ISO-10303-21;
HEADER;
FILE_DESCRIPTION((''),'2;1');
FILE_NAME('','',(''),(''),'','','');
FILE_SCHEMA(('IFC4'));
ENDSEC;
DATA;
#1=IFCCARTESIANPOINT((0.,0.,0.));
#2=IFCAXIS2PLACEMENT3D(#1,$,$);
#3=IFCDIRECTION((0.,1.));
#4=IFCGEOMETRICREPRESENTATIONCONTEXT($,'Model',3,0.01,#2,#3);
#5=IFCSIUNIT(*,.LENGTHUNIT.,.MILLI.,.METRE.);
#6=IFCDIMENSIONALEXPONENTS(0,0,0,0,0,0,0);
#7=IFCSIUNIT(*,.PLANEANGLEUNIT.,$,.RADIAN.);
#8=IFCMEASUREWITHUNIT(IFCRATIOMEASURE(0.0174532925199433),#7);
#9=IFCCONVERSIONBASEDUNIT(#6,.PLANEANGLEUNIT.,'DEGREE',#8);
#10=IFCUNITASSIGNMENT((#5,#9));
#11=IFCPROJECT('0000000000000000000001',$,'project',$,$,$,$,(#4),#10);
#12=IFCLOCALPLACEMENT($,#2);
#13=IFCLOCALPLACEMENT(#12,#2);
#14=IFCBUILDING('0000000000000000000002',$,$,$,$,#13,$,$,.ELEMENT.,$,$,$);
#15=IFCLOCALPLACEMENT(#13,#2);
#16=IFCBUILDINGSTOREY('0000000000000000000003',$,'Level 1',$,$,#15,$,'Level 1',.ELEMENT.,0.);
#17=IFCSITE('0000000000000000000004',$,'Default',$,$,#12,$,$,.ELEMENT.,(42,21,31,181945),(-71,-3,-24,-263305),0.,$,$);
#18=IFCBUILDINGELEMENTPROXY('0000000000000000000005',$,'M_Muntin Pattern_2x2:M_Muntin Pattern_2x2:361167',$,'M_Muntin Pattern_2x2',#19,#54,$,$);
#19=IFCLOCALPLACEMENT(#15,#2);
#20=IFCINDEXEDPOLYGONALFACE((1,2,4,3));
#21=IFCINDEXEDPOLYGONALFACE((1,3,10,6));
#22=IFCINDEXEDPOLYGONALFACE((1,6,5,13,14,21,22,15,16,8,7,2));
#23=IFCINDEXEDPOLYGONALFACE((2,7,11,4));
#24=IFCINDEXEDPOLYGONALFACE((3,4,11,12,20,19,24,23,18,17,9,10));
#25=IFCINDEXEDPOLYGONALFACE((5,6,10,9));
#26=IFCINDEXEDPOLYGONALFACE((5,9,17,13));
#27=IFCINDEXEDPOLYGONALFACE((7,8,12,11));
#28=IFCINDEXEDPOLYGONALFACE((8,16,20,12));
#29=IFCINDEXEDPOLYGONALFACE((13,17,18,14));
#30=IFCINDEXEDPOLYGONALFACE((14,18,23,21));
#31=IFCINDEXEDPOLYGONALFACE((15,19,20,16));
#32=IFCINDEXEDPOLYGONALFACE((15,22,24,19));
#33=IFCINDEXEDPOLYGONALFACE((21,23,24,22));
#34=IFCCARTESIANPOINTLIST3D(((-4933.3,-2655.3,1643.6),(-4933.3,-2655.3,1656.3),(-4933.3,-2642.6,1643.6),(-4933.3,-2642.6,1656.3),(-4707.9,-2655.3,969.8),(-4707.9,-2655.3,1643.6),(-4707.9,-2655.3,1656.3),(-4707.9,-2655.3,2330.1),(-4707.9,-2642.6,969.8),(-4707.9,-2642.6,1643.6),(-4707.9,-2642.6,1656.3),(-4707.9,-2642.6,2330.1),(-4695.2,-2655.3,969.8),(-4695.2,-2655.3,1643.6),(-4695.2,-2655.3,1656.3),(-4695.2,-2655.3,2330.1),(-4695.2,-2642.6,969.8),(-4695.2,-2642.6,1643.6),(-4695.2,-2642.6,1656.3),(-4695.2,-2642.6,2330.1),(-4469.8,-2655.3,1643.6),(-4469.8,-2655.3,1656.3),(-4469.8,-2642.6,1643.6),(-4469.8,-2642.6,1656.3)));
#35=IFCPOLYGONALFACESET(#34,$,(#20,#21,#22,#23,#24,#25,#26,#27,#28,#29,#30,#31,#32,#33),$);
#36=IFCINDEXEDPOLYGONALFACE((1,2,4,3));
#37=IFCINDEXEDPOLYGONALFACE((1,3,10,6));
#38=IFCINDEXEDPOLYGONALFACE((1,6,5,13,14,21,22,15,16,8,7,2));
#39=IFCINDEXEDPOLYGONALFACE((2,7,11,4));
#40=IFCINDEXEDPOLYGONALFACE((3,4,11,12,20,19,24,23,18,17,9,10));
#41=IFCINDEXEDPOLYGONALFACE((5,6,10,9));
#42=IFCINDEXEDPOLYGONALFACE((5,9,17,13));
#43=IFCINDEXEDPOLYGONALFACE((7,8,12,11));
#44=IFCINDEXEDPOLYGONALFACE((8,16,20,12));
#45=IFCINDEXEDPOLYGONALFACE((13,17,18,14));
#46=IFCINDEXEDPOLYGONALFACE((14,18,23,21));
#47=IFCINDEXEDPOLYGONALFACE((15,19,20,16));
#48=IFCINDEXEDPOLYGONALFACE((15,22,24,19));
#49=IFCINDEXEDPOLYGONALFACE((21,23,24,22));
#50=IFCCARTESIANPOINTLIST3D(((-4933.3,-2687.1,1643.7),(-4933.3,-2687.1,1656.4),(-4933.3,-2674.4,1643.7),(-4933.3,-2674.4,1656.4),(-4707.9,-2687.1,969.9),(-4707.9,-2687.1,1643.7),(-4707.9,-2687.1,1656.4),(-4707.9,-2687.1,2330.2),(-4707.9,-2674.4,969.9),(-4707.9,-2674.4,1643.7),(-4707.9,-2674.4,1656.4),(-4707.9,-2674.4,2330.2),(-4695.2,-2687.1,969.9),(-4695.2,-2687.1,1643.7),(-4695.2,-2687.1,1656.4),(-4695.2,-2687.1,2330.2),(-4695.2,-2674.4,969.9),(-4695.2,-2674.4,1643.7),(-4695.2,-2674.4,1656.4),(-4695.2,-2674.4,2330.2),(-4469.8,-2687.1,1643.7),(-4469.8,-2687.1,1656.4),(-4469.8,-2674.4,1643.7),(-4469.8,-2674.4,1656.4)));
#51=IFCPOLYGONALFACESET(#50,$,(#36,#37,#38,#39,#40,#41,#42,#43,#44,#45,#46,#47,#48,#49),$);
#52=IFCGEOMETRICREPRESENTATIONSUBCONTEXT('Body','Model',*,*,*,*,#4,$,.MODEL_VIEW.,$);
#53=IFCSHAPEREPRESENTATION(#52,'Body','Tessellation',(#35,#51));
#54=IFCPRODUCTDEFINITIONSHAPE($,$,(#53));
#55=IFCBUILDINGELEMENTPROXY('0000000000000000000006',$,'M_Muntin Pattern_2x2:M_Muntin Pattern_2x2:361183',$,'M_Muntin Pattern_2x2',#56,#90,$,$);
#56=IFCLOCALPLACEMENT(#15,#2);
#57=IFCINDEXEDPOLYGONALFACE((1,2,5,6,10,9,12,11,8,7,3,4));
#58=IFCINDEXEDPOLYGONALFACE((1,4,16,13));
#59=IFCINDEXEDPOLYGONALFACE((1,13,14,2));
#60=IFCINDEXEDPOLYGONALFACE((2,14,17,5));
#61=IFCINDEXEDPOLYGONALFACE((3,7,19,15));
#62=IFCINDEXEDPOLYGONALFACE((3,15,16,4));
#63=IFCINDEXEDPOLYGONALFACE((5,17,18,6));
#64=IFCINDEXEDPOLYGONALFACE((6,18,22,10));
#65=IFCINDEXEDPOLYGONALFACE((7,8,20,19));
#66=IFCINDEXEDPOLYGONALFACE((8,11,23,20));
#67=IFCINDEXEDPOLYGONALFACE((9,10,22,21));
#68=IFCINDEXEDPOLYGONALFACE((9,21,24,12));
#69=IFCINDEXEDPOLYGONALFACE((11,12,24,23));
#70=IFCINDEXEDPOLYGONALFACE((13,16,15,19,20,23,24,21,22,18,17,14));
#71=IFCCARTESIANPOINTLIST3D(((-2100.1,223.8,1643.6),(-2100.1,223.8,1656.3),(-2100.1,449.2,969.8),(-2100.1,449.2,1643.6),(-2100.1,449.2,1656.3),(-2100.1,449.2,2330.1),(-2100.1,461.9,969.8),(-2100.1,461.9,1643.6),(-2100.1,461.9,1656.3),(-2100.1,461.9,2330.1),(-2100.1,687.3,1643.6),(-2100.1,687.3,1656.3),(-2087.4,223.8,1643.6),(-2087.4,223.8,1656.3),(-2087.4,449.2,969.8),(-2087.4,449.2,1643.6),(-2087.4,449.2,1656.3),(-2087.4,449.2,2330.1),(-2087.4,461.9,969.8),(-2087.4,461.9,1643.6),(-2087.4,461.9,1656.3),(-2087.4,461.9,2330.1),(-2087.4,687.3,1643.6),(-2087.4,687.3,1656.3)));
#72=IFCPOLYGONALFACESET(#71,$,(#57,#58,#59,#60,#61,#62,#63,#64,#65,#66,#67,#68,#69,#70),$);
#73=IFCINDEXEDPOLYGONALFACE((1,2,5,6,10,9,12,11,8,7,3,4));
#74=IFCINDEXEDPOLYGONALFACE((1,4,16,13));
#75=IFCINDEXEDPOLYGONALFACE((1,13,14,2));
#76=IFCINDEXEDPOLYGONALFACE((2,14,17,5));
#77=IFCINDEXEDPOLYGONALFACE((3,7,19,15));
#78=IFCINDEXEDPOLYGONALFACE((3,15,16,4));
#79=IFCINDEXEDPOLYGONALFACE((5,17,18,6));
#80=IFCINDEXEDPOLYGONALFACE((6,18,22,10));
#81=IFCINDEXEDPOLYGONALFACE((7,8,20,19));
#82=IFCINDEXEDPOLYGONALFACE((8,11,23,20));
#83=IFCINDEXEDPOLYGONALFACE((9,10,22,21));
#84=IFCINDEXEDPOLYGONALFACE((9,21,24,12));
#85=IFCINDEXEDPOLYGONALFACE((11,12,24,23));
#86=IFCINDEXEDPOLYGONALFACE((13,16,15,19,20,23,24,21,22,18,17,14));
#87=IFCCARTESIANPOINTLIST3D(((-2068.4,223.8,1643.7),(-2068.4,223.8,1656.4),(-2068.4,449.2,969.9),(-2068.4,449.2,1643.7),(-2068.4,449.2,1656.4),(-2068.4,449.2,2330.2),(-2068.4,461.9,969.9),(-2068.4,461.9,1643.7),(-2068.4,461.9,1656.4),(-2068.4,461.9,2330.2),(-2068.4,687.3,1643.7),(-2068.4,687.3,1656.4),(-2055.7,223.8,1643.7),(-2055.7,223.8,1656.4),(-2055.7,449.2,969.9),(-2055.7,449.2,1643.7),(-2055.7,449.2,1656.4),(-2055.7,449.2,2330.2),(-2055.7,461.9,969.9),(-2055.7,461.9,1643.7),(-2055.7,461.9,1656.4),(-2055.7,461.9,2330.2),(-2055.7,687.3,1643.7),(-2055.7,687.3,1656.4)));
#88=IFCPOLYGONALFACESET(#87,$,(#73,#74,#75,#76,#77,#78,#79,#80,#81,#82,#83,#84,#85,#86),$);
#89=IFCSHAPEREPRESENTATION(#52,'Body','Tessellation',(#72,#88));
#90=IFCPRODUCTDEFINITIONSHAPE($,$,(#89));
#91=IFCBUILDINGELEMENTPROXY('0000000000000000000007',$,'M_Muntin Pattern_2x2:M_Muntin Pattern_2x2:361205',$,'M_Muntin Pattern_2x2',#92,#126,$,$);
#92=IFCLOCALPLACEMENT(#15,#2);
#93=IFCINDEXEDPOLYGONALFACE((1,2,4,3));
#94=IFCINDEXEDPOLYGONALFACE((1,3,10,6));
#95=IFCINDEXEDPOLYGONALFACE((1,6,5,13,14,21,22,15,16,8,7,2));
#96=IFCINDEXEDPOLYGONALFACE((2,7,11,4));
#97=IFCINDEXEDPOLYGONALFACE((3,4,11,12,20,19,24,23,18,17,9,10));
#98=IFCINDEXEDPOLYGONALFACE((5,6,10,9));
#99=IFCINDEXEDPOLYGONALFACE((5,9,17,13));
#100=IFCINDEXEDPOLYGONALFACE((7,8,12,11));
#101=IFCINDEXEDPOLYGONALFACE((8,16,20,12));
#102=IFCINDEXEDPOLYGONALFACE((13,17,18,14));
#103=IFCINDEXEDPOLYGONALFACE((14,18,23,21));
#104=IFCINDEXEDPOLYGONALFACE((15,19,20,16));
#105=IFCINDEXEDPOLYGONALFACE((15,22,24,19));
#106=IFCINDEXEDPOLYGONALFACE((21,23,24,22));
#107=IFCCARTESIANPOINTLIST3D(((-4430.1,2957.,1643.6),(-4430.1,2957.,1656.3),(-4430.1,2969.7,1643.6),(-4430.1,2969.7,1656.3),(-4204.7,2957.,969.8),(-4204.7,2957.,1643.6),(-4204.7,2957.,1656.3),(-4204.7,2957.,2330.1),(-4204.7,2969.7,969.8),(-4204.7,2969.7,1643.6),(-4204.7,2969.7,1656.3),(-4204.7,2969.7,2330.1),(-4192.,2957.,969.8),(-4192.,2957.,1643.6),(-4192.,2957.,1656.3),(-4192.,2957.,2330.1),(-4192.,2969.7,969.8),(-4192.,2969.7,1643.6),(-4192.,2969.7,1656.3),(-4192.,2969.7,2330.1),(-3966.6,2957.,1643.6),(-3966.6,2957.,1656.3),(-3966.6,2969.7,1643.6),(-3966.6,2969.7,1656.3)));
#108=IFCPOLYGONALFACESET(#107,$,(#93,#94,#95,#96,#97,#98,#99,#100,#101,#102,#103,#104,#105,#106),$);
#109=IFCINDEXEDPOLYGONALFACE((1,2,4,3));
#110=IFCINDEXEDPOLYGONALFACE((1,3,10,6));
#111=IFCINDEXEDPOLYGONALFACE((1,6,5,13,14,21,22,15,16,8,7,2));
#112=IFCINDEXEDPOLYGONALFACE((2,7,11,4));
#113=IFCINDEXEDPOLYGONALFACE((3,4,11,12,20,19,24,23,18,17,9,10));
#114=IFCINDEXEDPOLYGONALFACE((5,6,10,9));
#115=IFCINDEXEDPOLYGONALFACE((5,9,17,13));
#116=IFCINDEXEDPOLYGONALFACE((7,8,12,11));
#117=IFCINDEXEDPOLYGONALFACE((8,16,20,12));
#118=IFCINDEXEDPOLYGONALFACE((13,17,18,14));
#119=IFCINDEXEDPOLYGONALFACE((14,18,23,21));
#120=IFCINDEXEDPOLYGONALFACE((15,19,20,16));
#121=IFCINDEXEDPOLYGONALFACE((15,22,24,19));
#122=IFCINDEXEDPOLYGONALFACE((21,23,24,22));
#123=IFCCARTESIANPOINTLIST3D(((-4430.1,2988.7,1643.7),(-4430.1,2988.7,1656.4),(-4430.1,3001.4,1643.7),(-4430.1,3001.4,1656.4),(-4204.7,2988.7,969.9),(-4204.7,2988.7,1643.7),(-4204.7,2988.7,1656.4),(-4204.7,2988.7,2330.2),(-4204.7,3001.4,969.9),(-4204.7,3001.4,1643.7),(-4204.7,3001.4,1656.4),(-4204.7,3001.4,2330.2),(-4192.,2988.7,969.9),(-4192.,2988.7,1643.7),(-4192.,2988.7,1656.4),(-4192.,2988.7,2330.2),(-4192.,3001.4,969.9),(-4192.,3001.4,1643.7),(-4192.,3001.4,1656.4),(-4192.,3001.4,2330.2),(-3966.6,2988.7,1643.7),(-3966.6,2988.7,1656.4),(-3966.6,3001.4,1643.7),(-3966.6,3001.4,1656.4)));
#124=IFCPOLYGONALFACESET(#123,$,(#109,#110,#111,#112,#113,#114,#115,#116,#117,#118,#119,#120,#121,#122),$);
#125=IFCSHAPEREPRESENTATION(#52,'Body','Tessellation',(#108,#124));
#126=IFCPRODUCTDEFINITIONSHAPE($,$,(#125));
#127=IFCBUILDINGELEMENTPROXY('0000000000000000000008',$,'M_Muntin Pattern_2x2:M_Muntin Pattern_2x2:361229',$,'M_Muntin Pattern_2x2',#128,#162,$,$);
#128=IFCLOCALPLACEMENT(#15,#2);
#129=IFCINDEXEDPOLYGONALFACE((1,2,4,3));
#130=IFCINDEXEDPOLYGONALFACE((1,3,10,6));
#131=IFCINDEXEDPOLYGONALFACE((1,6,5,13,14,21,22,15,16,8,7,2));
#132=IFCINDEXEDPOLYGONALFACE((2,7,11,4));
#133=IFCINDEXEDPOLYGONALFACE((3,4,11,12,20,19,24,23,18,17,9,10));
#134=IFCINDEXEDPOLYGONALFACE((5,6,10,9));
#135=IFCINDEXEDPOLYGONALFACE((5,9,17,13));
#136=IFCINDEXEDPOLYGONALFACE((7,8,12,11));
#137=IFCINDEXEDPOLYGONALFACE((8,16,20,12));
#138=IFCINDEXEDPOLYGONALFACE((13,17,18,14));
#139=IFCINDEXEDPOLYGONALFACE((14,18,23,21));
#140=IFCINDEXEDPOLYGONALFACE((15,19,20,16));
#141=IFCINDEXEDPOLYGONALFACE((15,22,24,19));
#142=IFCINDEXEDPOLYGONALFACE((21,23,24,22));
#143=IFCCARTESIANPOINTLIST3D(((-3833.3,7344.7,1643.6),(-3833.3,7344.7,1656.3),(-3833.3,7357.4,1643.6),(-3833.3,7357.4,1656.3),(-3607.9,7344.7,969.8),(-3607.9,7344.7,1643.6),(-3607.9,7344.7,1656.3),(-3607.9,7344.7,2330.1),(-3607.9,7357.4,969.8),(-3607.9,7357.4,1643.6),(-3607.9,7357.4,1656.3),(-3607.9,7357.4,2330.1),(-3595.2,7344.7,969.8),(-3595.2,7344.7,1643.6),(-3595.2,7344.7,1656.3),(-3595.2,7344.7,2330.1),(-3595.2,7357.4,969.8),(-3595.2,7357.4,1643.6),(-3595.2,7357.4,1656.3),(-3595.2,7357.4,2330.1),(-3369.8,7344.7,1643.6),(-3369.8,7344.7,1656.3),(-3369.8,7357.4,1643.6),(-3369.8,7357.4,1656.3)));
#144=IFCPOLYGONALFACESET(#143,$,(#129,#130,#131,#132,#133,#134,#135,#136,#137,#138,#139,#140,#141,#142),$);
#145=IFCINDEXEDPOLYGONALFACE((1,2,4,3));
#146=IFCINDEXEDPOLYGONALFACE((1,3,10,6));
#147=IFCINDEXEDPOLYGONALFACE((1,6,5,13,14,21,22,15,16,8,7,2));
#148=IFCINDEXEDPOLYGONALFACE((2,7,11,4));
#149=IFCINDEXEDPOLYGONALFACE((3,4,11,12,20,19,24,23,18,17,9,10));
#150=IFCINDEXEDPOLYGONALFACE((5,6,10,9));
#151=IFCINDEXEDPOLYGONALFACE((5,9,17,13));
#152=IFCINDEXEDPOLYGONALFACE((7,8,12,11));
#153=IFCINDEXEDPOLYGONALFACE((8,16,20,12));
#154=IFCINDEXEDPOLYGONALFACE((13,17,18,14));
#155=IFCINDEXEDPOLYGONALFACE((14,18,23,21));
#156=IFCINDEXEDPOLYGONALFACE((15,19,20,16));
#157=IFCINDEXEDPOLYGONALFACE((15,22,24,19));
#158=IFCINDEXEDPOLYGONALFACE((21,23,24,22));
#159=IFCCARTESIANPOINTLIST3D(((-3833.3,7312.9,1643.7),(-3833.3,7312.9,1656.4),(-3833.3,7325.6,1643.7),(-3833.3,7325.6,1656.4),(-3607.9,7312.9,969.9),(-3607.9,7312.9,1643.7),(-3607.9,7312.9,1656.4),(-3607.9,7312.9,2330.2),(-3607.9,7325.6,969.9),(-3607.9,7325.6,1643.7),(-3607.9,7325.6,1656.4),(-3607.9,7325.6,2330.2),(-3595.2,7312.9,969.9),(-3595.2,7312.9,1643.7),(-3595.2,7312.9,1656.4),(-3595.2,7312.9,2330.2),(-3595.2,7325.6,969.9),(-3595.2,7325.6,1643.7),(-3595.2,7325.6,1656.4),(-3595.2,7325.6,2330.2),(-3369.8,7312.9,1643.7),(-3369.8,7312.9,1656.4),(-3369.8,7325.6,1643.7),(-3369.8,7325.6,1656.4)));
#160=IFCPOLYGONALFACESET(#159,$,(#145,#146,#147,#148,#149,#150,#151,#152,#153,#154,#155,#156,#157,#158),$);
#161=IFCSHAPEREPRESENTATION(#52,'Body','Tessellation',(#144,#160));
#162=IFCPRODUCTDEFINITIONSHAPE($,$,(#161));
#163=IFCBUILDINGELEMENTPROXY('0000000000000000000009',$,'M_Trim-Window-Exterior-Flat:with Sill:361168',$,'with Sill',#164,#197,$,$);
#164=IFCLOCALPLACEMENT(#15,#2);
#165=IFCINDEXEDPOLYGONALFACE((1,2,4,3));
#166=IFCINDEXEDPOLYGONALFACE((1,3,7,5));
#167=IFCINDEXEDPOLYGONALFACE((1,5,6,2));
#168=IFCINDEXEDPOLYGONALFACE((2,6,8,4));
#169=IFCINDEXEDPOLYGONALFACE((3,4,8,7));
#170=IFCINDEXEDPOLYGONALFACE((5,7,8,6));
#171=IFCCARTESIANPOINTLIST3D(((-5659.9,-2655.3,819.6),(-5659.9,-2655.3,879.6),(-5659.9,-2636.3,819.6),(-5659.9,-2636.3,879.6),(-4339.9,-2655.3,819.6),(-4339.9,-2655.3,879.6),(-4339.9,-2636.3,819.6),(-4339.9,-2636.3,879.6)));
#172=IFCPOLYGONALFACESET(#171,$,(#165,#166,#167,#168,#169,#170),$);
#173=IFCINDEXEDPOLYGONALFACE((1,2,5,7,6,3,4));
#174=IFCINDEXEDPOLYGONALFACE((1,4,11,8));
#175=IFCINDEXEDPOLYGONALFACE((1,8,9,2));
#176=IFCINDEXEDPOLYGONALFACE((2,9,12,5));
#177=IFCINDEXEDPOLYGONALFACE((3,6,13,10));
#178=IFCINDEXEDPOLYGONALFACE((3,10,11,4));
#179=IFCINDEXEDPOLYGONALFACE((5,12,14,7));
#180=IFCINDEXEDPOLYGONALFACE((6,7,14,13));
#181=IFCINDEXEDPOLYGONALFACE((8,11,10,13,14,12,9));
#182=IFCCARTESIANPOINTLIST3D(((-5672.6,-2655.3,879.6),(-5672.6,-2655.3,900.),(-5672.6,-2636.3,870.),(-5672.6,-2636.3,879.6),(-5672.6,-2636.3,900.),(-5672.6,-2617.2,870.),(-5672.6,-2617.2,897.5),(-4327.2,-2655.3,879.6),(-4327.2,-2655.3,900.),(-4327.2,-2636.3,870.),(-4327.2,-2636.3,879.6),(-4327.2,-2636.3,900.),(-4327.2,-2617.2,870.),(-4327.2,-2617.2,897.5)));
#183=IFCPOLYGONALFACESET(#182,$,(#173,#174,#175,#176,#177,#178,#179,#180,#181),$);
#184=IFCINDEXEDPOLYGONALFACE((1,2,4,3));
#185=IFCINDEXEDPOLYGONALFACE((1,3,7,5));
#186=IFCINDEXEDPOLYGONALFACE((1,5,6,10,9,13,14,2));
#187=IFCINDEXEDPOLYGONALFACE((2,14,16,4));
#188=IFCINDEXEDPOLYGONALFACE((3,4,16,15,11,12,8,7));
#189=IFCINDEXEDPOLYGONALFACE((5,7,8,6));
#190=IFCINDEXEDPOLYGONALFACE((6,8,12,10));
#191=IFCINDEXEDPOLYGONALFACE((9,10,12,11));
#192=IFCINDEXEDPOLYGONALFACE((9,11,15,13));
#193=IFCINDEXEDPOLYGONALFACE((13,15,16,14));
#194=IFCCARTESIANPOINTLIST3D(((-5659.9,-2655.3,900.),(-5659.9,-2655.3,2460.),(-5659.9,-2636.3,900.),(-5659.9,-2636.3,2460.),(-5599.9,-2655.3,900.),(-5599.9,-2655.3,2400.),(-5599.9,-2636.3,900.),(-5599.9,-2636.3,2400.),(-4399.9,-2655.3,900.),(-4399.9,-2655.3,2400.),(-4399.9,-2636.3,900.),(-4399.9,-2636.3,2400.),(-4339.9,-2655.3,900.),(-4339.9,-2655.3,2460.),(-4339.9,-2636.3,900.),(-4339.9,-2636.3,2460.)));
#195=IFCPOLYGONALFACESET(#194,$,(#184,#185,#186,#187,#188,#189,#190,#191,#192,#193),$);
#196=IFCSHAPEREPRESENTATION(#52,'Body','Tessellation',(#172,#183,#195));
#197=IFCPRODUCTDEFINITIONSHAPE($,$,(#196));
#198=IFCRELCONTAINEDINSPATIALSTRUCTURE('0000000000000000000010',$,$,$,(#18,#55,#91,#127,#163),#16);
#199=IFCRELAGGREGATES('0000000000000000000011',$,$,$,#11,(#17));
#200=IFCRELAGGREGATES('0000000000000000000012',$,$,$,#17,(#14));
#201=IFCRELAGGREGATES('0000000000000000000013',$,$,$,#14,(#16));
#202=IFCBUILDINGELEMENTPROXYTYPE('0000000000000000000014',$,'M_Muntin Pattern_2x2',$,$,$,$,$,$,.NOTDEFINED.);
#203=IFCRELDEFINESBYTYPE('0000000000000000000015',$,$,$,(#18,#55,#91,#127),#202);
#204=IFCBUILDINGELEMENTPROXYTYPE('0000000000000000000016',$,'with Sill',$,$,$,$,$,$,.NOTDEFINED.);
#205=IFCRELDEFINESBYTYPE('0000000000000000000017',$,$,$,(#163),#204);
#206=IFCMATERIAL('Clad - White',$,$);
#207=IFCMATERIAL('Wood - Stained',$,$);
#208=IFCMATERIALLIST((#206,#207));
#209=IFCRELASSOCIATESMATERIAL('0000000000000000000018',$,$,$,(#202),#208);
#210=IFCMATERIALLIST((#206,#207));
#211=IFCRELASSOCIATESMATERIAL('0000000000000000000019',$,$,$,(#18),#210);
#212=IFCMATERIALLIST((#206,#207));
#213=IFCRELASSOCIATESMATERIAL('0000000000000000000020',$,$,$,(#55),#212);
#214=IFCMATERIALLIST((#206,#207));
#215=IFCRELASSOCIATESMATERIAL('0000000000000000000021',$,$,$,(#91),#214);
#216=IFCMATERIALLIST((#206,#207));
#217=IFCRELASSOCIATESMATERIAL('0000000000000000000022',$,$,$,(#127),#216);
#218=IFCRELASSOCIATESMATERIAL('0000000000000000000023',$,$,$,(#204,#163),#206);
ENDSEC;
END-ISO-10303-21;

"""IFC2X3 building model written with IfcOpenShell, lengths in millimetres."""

from ifc_helpers import new_model, entity, si_unit, converted_unit, direction, frame, frame_2d, origin, place, context, subcontext, project, spatial, polyline, rectangle, outline, extrude, source, transform, mapped, material, material_list, type_object, type_shapes, element, save


model = new_model("IFC2X3")

# Units and contexts
model_context = context("Model", 3, precision=0.01, world=origin(), true_north=direction((0.0, 1.0)))
body_context = subcontext(model_context, "Body", "Model", "MODEL_VIEW")
ifc_project = project(units=[si_unit("LENGTHUNIT", "METRE", prefix="MILLI"), converted_unit("PLANEANGLEUNIT", "DEGREE", entity("IfcRatioMeasure", 0.0174532925199433), si_unit("PLANEANGLEUNIT", "RADIAN"), dimensions=[0, 0, 0, 0, 0, 0, 0])], contexts=[model_context])

# Site, building, storey
site_placement = place(None, origin())
site = spatial("IfcSite", under=ifc_project, at=site_placement, Name="Default", CompositionType="ELEMENT", RefLatitude=(42, 21, 31, 181945), RefLongitude=(-71, -3, -24, -263305), RefElevation=0.0)
building_placement = place(site_placement, origin())
building = spatial("IfcBuilding", under=site, at=building_placement, CompositionType="ELEMENT")
storey_placement = place(building_placement, origin())
storey = spatial("IfcBuildingStorey", under=building, at=storey_placement, Name="Level 1", LongName="Level 1", CompositionType="ELEMENT", Elevation=0.0)

# Building element proxies
ifc_material_1 = material(Name="Clad - White")
ifc_material_2 = material(Name="Wood - Stained")
ifc_material_list_1 = material_list([ifc_material_1, ifc_material_2])
ifc_material_list_2 = material_list([ifc_material_1, ifc_material_2])
building_element_proxy_type_1 = type_object("IfcBuildingElementProxyType", Name="M_Muntin Pattern_2x2", PredefinedType="NOTDEFINED", material=ifc_material_list_2)
shared_shape_1 = source(origin(), body_context, "Body", "SweptSolid", [
    extrude(outline(polyline([(6.4, -6.4), (680.1, -6.4), (680.1, 6.3), (6.4, 6.3), (6.4, 231.7), (-6.3, 231.7), (-6.3, 6.3), (-680.2, 6.3), (-680.2, -6.4), (-6.3, -6.4), (-6.3, -231.7), (6.4, -231.7), (6.4, -6.4)])), frame((0.0, -22.2, 680.1), z_axis=(0.0, 1.0, 0.0), x_axis=(0.0, 0.0, 1.0)), (0.0, 0.0, 1.0), 12.7),
    extrude(outline(polyline([(6.4, -6.4), (680.1, -6.4), (680.1, 6.3), (6.4, 6.3), (6.4, 231.7), (-6.3, 231.7), (-6.3, 6.3), (-680.2, 6.3), (-680.2, -6.4), (-6.3, -6.4), (-6.3, -231.7), (6.4, -231.7), (6.4, -6.4)])), frame((0.0, 9.5, 680.2), z_axis=(0.0, 1.0, 0.0), x_axis=(0.0, 0.0, 1.0)), (0.0, 0.0, 1.0), 12.7),
])
type_shapes(building_element_proxy_type_1, [shared_shape_1])
proxy_1_placement = place(storey_placement, frame((-4701.5, -2664.9, 969.9), z_axis=(0.0, 0.0, 1.0), x_axis=(-1.0, 0.0, 0.0)))
element("IfcBuildingElementProxy", 1, at=proxy_1_placement, inside=storey, type_object=building_element_proxy_type_1, material=ifc_material_list_1, Name="M_Muntin Pattern_2x2:M_Muntin Pattern_2x2:361167", ObjectType="M_Muntin Pattern_2x2", context=body_context, shape_type="MappedRepresentation", body=[
    mapped(shared_shape_1, transform((0.0, 0.0, 0.0), scale=1.0)),
])
ifc_material_list_3 = material_list([ifc_material_1, ifc_material_2])
proxy_2_placement = place(storey_placement, frame((-2077.9, 455.6, 969.9), z_axis=(0.0, 0.0, 1.0), x_axis=(0.0, -1.0, 0.0)))
element("IfcBuildingElementProxy", 2, at=proxy_2_placement, inside=storey, type_object=building_element_proxy_type_1, material=ifc_material_list_3, Name="M_Muntin Pattern_2x2:M_Muntin Pattern_2x2:361183", ObjectType="M_Muntin Pattern_2x2", context=body_context, shape_type="MappedRepresentation", body=[
    mapped(shared_shape_1, transform((0.0, 0.0, 0.0), scale=1.0)),
])
ifc_material_list_4 = material_list([ifc_material_1, ifc_material_2])
proxy_3_placement = place(storey_placement, frame((-4198.4, 2979.2, 969.9)))
element("IfcBuildingElementProxy", 3, at=proxy_3_placement, inside=storey, type_object=building_element_proxy_type_1, material=ifc_material_list_4, Name="M_Muntin Pattern_2x2:M_Muntin Pattern_2x2:361205", ObjectType="M_Muntin Pattern_2x2", context=body_context, shape_type="MappedRepresentation", body=[
    mapped(shared_shape_1, transform((0.0, 0.0, 0.0), scale=1.0)),
])
ifc_material_list_5 = material_list([ifc_material_1, ifc_material_2])
proxy_4_placement = place(storey_placement, frame((-3601.5, 7335.1, 969.9), z_axis=(0.0, 0.0, 1.0), x_axis=(-1.0, 0.0, 0.0)))
element("IfcBuildingElementProxy", 4, at=proxy_4_placement, inside=storey, type_object=building_element_proxy_type_1, material=ifc_material_list_5, Name="M_Muntin Pattern_2x2:M_Muntin Pattern_2x2:361229", ObjectType="M_Muntin Pattern_2x2", context=body_context, shape_type="MappedRepresentation", body=[
    mapped(shared_shape_1, transform((0.0, 0.0, 0.0), scale=1.0)),
])
building_element_proxy_type_2 = type_object("IfcBuildingElementProxyType", Name="with Sill", PredefinedType="NOTDEFINED", material=ifc_material_1)
shared_shape_2 = source(origin(), body_context, "Body", "SweptSolid", [
    extrude(rectangle(XDim=1320.0, YDim=60.0, at=frame_2d((0.0, 0.0), x_axis=(1.0, 0.0))), frame((0.0, -1550.4, 0.0), z_axis=(0.0, 0.0, 1.0), x_axis=(-1.0, 0.0, 0.0)), (0.0, 0.0, 1.0), 19.1),
    extrude(outline(polyline([(-19.0, -15.2), (0.0, -15.2), (0.0, -5.7), (19.0, -5.7), (19.0, 14.8), (0.0, 14.8), (-19.0, 12.3), (-19.0, -15.2)])), frame((-672.7, -1514.8, 19.0), z_axis=(1.0, 0.0, 0.0), x_axis=(0.0, 0.0, -1.0)), (0.0, 0.0, 1.0), 1345.4),
    extrude(outline(polyline([(-795.0, -660.0), (765.0, -660.0), (765.0, -600.0), (-735.0, -600.0), (-735.0, 600.0), (765.0, 600.0), (765.0, 660.0), (-795.0, 660.0), (-795.0, -660.0)])), frame((0.0, -735.0, 0.0), z_axis=(0.0, 0.0, 1.0), x_axis=(0.0, -1.0, 0.0)), (0.0, 0.0, 1.0), 19.1),
])
type_shapes(building_element_proxy_type_2, [shared_shape_2])
for number, where, z_axis, x_axis, name in (
    (5, (-4999.9, -2655.3, 2400.0), (0.0, 1.0, 0.0), (-1.0, 0.0, 0.0), "M_Trim-Window-Exterior-Flat:with Sill:361168"),
):
    element("IfcBuildingElementProxy", number, at=place(storey_placement, frame(where, z_axis=z_axis, x_axis=x_axis)), inside=storey, type_object=building_element_proxy_type_2, material=ifc_material_1, Name=name, ObjectType="with Sill", context=body_context, shape_type="MappedRepresentation", body=[
        mapped(shared_shape_2, transform((0.0, 0.0, 0.0), scale=1.0)),
    ])

save(model, "model.ifc")
